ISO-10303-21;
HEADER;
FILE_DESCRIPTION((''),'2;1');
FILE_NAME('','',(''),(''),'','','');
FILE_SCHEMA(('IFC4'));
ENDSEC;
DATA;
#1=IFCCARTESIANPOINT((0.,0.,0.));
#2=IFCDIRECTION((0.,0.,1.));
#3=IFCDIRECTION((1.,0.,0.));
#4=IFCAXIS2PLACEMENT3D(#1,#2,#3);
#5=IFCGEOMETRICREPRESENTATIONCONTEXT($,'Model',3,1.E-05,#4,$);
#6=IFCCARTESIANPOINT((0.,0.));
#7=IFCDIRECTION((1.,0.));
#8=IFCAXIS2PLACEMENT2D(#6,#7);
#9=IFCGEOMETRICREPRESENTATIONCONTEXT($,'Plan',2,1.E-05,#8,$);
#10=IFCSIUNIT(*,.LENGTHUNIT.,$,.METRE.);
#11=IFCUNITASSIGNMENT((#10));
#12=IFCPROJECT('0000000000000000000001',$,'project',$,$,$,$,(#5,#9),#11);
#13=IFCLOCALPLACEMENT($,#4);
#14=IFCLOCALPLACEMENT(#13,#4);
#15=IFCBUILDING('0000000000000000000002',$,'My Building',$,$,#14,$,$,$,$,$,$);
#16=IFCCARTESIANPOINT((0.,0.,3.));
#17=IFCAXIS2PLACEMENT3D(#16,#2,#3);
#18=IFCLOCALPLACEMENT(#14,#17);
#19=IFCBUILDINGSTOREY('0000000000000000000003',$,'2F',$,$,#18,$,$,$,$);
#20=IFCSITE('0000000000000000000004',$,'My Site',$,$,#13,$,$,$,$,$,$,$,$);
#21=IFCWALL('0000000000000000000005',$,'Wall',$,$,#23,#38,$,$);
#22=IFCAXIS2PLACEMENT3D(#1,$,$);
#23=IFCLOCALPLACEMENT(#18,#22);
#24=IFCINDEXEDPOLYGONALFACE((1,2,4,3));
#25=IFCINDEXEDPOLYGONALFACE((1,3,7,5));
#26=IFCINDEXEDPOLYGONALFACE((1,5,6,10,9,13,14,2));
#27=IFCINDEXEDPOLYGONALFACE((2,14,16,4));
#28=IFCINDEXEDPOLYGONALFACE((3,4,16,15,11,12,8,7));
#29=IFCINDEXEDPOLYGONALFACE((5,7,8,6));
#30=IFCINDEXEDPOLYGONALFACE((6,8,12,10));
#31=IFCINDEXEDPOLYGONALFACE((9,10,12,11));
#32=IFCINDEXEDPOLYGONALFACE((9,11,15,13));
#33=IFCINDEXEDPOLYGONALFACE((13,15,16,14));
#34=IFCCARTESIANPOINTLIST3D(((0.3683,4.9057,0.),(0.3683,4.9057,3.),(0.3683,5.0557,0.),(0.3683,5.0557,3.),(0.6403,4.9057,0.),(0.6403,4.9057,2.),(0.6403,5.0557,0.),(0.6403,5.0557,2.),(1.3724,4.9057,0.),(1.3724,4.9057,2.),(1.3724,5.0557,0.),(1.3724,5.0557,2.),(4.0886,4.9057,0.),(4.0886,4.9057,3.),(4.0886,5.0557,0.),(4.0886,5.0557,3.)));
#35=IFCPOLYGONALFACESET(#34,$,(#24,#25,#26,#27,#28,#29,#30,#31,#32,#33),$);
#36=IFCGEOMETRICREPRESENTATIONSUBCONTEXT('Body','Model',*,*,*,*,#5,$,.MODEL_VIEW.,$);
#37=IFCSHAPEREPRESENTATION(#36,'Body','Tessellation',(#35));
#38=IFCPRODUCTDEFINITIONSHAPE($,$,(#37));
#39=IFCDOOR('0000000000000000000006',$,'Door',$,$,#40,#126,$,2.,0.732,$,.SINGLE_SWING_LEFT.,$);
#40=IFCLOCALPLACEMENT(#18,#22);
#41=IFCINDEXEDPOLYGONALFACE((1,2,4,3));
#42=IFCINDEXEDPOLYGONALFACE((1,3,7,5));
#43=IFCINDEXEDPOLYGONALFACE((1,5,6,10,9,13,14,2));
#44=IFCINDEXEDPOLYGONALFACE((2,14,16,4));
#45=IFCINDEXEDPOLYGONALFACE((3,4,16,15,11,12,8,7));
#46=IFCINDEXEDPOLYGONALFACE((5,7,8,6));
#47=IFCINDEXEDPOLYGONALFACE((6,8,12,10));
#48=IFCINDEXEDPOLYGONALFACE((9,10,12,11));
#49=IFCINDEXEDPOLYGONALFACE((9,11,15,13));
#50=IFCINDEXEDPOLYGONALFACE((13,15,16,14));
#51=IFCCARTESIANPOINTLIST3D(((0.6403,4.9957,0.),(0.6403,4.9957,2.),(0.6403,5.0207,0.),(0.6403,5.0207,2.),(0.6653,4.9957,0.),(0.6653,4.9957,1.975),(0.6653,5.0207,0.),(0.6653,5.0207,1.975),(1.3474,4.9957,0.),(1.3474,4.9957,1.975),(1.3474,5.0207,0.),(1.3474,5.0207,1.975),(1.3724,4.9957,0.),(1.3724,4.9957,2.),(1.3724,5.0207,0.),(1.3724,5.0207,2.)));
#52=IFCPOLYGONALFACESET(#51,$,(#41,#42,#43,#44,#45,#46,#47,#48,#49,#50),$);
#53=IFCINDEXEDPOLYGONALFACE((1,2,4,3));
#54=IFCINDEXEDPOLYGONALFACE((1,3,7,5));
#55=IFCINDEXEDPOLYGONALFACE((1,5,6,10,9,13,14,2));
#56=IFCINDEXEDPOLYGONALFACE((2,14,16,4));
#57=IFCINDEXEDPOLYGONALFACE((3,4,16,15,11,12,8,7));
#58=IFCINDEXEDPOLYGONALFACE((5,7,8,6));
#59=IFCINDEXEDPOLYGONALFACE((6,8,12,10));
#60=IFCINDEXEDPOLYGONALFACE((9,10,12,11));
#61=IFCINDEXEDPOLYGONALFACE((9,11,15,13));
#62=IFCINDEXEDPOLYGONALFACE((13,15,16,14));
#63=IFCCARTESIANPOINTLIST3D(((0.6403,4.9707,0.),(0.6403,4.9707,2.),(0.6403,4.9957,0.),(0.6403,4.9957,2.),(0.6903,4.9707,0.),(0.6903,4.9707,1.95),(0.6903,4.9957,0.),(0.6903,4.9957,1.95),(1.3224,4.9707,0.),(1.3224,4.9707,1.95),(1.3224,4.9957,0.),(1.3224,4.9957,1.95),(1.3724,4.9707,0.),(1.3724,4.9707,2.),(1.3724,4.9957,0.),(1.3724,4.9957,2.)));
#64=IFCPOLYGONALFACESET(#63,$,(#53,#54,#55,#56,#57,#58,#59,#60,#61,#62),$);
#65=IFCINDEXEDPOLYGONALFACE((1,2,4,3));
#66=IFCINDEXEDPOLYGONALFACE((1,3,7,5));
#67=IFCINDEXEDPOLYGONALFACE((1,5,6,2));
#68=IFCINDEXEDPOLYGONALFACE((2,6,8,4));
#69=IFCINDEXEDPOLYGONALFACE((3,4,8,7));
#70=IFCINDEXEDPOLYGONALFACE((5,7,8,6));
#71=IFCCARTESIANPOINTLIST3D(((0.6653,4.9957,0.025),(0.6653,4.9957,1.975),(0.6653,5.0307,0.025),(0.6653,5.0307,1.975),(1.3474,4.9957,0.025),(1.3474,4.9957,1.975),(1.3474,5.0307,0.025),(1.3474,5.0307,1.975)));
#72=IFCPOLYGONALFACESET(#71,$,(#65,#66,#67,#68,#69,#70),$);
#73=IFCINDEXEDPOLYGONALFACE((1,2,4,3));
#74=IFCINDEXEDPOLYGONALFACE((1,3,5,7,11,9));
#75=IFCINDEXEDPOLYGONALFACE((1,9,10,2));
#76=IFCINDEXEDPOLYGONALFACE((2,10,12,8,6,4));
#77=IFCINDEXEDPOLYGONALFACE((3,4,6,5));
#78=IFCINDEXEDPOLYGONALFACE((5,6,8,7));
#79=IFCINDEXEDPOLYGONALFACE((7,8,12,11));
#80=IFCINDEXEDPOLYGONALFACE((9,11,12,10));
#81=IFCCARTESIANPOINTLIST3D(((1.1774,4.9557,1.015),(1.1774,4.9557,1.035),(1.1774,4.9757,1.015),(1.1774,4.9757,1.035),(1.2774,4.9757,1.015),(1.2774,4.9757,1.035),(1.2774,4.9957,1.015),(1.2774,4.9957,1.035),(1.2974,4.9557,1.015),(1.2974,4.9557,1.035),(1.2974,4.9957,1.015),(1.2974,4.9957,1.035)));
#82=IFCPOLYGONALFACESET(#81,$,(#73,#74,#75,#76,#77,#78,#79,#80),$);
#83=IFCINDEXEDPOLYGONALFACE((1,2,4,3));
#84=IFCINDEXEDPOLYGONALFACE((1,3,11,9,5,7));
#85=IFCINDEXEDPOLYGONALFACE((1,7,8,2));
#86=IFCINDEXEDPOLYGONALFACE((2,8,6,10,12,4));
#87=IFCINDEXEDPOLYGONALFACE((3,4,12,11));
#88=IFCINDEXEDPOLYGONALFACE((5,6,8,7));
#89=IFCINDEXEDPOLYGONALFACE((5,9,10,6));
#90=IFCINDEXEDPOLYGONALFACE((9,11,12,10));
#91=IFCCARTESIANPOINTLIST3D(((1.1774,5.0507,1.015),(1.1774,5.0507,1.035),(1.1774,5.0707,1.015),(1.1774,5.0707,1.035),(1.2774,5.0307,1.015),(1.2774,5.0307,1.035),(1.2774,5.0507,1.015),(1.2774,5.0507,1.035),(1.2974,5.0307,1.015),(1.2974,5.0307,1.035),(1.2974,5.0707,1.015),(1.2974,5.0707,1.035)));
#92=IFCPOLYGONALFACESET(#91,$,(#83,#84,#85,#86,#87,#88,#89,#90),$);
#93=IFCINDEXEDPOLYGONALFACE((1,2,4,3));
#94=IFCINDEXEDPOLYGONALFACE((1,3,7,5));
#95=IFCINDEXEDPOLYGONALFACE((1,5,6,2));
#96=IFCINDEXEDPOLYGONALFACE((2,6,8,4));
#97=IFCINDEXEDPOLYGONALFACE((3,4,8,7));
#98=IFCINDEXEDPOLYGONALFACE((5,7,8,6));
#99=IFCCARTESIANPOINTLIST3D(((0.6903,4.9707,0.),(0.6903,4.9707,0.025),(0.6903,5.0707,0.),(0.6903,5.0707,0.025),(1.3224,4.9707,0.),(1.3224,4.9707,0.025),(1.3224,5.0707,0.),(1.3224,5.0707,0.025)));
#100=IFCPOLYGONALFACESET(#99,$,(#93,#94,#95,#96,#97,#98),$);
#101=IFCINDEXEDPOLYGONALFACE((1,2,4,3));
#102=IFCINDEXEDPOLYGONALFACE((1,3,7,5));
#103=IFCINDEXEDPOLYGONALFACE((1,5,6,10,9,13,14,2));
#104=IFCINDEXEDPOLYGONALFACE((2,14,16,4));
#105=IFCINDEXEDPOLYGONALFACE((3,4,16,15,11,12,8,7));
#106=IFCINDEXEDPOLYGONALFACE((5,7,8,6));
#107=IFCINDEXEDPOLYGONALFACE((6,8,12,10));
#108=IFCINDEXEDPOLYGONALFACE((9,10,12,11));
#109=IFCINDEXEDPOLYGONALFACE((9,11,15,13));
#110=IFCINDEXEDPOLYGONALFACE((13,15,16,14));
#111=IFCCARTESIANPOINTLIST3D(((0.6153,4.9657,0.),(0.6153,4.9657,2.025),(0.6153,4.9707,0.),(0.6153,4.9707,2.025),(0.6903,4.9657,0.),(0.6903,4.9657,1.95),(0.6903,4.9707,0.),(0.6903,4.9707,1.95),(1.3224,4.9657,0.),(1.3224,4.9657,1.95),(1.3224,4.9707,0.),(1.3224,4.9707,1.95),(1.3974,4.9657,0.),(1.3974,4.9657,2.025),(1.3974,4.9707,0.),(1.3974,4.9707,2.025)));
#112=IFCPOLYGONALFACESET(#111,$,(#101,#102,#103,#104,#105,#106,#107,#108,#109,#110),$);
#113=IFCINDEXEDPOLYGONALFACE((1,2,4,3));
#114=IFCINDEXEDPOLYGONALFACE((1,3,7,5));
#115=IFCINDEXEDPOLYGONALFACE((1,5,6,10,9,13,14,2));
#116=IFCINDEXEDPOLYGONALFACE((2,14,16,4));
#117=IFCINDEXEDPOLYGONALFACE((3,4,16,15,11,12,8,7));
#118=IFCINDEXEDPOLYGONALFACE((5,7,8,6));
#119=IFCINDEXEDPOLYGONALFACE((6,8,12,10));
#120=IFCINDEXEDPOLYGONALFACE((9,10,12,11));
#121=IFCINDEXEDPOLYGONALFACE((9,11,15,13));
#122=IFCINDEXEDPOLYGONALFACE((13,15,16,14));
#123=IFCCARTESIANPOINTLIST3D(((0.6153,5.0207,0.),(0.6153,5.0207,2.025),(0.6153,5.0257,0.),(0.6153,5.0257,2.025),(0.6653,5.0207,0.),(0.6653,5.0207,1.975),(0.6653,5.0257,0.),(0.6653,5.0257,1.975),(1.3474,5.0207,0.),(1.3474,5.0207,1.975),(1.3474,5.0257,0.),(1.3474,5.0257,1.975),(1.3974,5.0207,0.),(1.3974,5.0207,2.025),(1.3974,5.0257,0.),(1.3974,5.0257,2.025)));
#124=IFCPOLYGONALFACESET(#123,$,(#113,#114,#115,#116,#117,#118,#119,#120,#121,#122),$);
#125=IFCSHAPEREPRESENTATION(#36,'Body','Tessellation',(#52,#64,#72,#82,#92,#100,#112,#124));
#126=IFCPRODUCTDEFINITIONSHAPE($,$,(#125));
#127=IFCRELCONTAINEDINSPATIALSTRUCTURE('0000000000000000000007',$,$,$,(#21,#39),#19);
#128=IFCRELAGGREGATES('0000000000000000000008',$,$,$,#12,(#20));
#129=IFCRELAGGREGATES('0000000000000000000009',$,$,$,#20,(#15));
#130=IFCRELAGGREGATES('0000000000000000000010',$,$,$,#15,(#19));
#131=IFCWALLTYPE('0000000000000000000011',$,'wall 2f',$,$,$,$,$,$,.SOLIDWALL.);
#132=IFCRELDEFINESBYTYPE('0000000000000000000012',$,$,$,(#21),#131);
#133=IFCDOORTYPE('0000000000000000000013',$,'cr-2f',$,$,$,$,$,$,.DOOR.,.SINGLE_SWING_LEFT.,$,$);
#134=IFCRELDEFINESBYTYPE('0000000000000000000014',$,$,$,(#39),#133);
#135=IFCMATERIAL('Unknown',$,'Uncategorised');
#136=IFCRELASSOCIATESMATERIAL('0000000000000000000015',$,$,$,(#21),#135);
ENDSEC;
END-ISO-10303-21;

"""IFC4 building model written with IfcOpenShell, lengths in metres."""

from ifc_helpers import new_model, entity, si_unit, frame, origin_with_axes, origin_2d_with_axis, place, context, subcontext, project, spatial, line, indexed_curve, outline, extrude, shape, source, transform, mapped, material, type_object, type_shapes, element, fill, save


model = new_model("IFC4")

# Units and contexts
model_context = context("Model", 3, precision=1e-05, world=origin_with_axes())
plan_context = context("Plan", 2, precision=1e-05, world=origin_2d_with_axis())
body_context_1 = subcontext(model_context, "Body", "Model", "MODEL_VIEW")
body_context_2 = subcontext(plan_context, "Body", "Plan", "PLAN_VIEW")
ifc_project = project(units=[si_unit("LENGTHUNIT", "METRE")], contexts=[model_context, plan_context])

# Site, building, storey
site_placement = place(None, origin_with_axes())
site = spatial("IfcSite", under=ifc_project, at=site_placement, Name="My Site")
building_placement = place(site_placement, origin_with_axes())
building = spatial("IfcBuilding", under=site, at=building_placement, Name="My Building")
storey_placement = place(building_placement, frame((0.0, 0.0, 3.0), z_axis=(0.0, 0.0, 1.0), x_axis=(1.0, 0.0, 0.0)))
storey = spatial("IfcBuildingStorey", under=building, at=storey_placement, Name="2F")

# Shared definitions
ifc_material = material(Name="Unknown", Category="Uncategorised")

# Shared definitions
wall_type_1 = type_object("IfcWallType", Name="wall 2f", PredefinedType="SOLIDWALL")

# Wall, opening, door
wall_1_placement = place(storey_placement, frame((0.3683, 4.9057, 0.0), z_axis=(0.0, 0.0, 1.0), x_axis=(1.0, 0.0, 0.0)))
wall_1 = element("IfcWall", 1, at=wall_1_placement, inside=storey, type_object=wall_type_1, material=ifc_material, Name="Wall", context=body_context_1, shape_type="SweptSolid", body=[
    extrude(outline(indexed_curve([(0.0, 0.0), (0.0, 0.15), (3.7202, 0.15), (3.7202, 0.0)], segments=[line(1, 2, 3, 4, 1)])), origin_with_axes(), (0.0, 0.0, 1.0), 3.0),
])
shared_shape_1 = source(origin_with_axes(), body_context_1, "Body", "SweptSolid", [
    extrude(outline(indexed_curve([(0.0, 0.0), (0.732, 0.0), (0.732, 2.0), (0.0, 2.0)], segments=[line(1, 2, 3, 4, 1)])), frame((0.0, -0.6, 0.0), z_axis=(0.0, -1.0, 0.0), x_axis=(1.0, 0.0, 0.0)), (0.0, 0.0, -1.0), 1.2),
])
opening_1_placement = place(wall_1_placement, frame((0.272, 0.065, 0.0), z_axis=(0.0, 0.0, 1.0), x_axis=(1.0, 0.0, 0.0)))
opening_1 = element("IfcOpeningElement", 2, at=opening_1_placement, cuts=wall_1, PredefinedType="OPENING", context=body_context_1, shape_type="MappedRepresentation", body=[
    mapped(shared_shape_1, transform((0.0, 0.0, 0.0), x_axis=(1.0, 0.0, 0.0), y_axis=(0.0, 1.0, 0.0), z_axis=(0.0, 0.0, 1.0), scale=1.0)),
])
door_type_1 = type_object("IfcDoorType", Name="cr-2f", OperationType="SINGLE_SWING_LEFT", PredefinedType="DOOR")
shared_shape_2 = source(origin_with_axes(), body_context_1, "Body", "SweptSolid", [
    extrude(outline(indexed_curve([(0.0, 0.0), (0.0, 2.0), (0.732, 2.0), (0.732, 0.0), (0.707, 0.0), (0.707, 1.975), (0.025, 1.975), (0.025, 0.0)], segments=[line(1, 2, 3, 4, 5, 6, 7, 8, 1)])), frame((0.0, 0.025, 0.0), z_axis=(0.0, -1.0, 0.0), x_axis=(1.0, 0.0, 0.0)), (0.0, 0.0, -1.0), 0.025),
    extrude(outline(indexed_curve([(0.0, 0.0), (0.0, 2.0), (0.732, 2.0), (0.732, 0.0), (0.682, 0.0), (0.682, 1.95), (0.05, 1.95), (0.05, 0.0)], segments=[line(1, 2, 3, 4, 5, 6, 7, 8, 1)])), frame((0.0, 0.0, 0.0), z_axis=(0.0, -1.0, 0.0), x_axis=(1.0, 0.0, 0.0)), (0.0, 0.0, -1.0), 0.025),
    extrude(outline(indexed_curve([(0.0, 0.0), (0.682, 0.0), (0.682, 0.035), (0.0, 0.035)], segments=[line(1, 2, 3, 4, 1)])), frame((0.025, 0.025, 0.025), z_axis=(0.0, 0.0, 1.0), x_axis=(1.0, 0.0, 0.0)), (0.0, 0.0, 1.0), 1.95),
    extrude(outline(indexed_curve([(0.0, 0.0), (0.0, -0.04), (-0.12, -0.04), (-0.12, -0.02), (-0.02, -0.02), (-0.02, 0.0)], segments=[line(1, 2, 3, 4, 5, 6, 1)])), frame((0.657, 0.025, 1.015), z_axis=(0.0, 0.0, 1.0), x_axis=(1.0, 0.0, 0.0)), (0.0, 0.0, 1.0), 0.02),
    extrude(outline(indexed_curve([(0.0, 0.0), (0.0, 0.04), (-0.12, 0.04), (-0.12, 0.02), (-0.02, 0.02), (-0.02, 0.0)], segments=[line(1, 2, 3, 4, 5, 6, 1)])), frame((0.657, 0.06, 1.015), z_axis=(0.0, 0.0, 1.0), x_axis=(1.0, 0.0, 0.0)), (0.0, 0.0, 1.0), 0.02),
    extrude(outline(indexed_curve([(0.0, 0.0), (0.632, 0.0), (0.632, 0.1), (0.0, 0.1)], segments=[line(1, 2, 3, 4, 1)])), frame((0.05, 0.0, 0.0), z_axis=(0.0, 0.0, 1.0), x_axis=(1.0, 0.0, 0.0)), (0.0, 0.0, 1.0), 0.025),
    extrude(outline(indexed_curve([(0.0, 0.0), (0.0, 2.025), (0.782, 2.025), (0.782, 0.0), (0.707, 0.0), (0.707, 1.95), (0.075, 1.95), (0.075, 0.0)], segments=[line(1, 2, 3, 4, 5, 6, 7, 8, 1)])), frame((-0.025, -0.005, 0.0), z_axis=(0.0, -1.0, 0.0), x_axis=(1.0, 0.0, 0.0)), (0.0, 0.0, -1.0), 0.005),
    extrude(outline(indexed_curve([(0.0, 0.0), (0.0, 2.025), (0.782, 2.025), (0.782, 0.0), (0.732, 0.0), (0.732, 1.975), (0.05, 1.975), (0.05, 0.0)], segments=[line(1, 2, 3, 4, 5, 6, 7, 8, 1)])), frame((-0.025, 0.05, 0.0), z_axis=(0.0, -1.0, 0.0), x_axis=(1.0, 0.0, 0.0)), (0.0, 0.0, -1.0), 0.005),
])
shared_shape_3 = source(origin_with_axes(), body_context_2, "Body", "Curve2D", [
    entity("IfcIndexedPolyCurve", entity("IfcCartesianPointList2D", [[0.0, 0.0], [0.0, 0.05], [0.025, 0.05], [0.025, 0.025], [0.05, 0.025], [0.05, 0.0]]), [entity("IfcLineIndex", [1, 2, 3, 4, 5, 6, 1])]),
    entity("IfcIndexedPolyCurve", entity("IfcCartesianPointList2D", [[0.732, 0.0], [0.732, 0.05], [0.707, 0.05], [0.707, 0.025], [0.682, 0.025], [0.682, 0.0]]), [entity("IfcLineIndex", [1, 2, 3, 4, 5, 6, 1])]),
    entity("IfcTrimmedCurve", entity("IfcEllipse", entity("IfcAxis2Placement2D", entity("IfcCartesianPoint", [0.06, 0.05]), entity("IfcDirection", [1.0, 0.0])), 0.647, 0.682), [entity("IfcCartesianPoint", [0.707, 0.05])], [entity("IfcCartesianPoint", [0.06, 0.732])], True, "CARTESIAN"),
    entity("IfcIndexedPolyCurve", entity("IfcCartesianPointList2D", [[0.025, 0.05], [0.06, 0.05], [0.06, 0.732], [0.025, 0.732]]), [entity("IfcLineIndex", [1, 2, 3, 4, 1])]),
])
type_shapes(door_type_1, [shared_shape_2, shared_shape_3])
door_1_placement = place(opening_1_placement, frame((0.0, 0.0, 0.0), z_axis=(0.0, 0.0, 1.0), x_axis=(1.0, 0.0, 0.0)))
door_1 = element("IfcDoor", 3, at=door_1_placement, inside=storey, type_object=door_type_1, Name="Door", OperationType="SINGLE_SWING_LEFT", OverallHeight=2.0, OverallWidth=0.732, shapes=[
    shape(body_context_1, "Body", "MappedRepresentation", [mapped(shared_shape_2, transform((0.0, 0.0, 0.0), x_axis=(1.0, 0.0, 0.0), y_axis=(0.0, 1.0, 0.0), z_axis=(0.0, 0.0, 1.0), scale=1.0))]),
    shape(body_context_2, "Body", "MappedRepresentation", [mapped(shared_shape_3, transform((0.0, 0.0, 0.0), x_axis=(1.0, 0.0, 0.0), y_axis=(0.0, 1.0, 0.0), z_axis=(0.0, 0.0, 1.0), scale=1.0))]),
])
fill(opening_1, door_1)

save(model, "model.ifc")
